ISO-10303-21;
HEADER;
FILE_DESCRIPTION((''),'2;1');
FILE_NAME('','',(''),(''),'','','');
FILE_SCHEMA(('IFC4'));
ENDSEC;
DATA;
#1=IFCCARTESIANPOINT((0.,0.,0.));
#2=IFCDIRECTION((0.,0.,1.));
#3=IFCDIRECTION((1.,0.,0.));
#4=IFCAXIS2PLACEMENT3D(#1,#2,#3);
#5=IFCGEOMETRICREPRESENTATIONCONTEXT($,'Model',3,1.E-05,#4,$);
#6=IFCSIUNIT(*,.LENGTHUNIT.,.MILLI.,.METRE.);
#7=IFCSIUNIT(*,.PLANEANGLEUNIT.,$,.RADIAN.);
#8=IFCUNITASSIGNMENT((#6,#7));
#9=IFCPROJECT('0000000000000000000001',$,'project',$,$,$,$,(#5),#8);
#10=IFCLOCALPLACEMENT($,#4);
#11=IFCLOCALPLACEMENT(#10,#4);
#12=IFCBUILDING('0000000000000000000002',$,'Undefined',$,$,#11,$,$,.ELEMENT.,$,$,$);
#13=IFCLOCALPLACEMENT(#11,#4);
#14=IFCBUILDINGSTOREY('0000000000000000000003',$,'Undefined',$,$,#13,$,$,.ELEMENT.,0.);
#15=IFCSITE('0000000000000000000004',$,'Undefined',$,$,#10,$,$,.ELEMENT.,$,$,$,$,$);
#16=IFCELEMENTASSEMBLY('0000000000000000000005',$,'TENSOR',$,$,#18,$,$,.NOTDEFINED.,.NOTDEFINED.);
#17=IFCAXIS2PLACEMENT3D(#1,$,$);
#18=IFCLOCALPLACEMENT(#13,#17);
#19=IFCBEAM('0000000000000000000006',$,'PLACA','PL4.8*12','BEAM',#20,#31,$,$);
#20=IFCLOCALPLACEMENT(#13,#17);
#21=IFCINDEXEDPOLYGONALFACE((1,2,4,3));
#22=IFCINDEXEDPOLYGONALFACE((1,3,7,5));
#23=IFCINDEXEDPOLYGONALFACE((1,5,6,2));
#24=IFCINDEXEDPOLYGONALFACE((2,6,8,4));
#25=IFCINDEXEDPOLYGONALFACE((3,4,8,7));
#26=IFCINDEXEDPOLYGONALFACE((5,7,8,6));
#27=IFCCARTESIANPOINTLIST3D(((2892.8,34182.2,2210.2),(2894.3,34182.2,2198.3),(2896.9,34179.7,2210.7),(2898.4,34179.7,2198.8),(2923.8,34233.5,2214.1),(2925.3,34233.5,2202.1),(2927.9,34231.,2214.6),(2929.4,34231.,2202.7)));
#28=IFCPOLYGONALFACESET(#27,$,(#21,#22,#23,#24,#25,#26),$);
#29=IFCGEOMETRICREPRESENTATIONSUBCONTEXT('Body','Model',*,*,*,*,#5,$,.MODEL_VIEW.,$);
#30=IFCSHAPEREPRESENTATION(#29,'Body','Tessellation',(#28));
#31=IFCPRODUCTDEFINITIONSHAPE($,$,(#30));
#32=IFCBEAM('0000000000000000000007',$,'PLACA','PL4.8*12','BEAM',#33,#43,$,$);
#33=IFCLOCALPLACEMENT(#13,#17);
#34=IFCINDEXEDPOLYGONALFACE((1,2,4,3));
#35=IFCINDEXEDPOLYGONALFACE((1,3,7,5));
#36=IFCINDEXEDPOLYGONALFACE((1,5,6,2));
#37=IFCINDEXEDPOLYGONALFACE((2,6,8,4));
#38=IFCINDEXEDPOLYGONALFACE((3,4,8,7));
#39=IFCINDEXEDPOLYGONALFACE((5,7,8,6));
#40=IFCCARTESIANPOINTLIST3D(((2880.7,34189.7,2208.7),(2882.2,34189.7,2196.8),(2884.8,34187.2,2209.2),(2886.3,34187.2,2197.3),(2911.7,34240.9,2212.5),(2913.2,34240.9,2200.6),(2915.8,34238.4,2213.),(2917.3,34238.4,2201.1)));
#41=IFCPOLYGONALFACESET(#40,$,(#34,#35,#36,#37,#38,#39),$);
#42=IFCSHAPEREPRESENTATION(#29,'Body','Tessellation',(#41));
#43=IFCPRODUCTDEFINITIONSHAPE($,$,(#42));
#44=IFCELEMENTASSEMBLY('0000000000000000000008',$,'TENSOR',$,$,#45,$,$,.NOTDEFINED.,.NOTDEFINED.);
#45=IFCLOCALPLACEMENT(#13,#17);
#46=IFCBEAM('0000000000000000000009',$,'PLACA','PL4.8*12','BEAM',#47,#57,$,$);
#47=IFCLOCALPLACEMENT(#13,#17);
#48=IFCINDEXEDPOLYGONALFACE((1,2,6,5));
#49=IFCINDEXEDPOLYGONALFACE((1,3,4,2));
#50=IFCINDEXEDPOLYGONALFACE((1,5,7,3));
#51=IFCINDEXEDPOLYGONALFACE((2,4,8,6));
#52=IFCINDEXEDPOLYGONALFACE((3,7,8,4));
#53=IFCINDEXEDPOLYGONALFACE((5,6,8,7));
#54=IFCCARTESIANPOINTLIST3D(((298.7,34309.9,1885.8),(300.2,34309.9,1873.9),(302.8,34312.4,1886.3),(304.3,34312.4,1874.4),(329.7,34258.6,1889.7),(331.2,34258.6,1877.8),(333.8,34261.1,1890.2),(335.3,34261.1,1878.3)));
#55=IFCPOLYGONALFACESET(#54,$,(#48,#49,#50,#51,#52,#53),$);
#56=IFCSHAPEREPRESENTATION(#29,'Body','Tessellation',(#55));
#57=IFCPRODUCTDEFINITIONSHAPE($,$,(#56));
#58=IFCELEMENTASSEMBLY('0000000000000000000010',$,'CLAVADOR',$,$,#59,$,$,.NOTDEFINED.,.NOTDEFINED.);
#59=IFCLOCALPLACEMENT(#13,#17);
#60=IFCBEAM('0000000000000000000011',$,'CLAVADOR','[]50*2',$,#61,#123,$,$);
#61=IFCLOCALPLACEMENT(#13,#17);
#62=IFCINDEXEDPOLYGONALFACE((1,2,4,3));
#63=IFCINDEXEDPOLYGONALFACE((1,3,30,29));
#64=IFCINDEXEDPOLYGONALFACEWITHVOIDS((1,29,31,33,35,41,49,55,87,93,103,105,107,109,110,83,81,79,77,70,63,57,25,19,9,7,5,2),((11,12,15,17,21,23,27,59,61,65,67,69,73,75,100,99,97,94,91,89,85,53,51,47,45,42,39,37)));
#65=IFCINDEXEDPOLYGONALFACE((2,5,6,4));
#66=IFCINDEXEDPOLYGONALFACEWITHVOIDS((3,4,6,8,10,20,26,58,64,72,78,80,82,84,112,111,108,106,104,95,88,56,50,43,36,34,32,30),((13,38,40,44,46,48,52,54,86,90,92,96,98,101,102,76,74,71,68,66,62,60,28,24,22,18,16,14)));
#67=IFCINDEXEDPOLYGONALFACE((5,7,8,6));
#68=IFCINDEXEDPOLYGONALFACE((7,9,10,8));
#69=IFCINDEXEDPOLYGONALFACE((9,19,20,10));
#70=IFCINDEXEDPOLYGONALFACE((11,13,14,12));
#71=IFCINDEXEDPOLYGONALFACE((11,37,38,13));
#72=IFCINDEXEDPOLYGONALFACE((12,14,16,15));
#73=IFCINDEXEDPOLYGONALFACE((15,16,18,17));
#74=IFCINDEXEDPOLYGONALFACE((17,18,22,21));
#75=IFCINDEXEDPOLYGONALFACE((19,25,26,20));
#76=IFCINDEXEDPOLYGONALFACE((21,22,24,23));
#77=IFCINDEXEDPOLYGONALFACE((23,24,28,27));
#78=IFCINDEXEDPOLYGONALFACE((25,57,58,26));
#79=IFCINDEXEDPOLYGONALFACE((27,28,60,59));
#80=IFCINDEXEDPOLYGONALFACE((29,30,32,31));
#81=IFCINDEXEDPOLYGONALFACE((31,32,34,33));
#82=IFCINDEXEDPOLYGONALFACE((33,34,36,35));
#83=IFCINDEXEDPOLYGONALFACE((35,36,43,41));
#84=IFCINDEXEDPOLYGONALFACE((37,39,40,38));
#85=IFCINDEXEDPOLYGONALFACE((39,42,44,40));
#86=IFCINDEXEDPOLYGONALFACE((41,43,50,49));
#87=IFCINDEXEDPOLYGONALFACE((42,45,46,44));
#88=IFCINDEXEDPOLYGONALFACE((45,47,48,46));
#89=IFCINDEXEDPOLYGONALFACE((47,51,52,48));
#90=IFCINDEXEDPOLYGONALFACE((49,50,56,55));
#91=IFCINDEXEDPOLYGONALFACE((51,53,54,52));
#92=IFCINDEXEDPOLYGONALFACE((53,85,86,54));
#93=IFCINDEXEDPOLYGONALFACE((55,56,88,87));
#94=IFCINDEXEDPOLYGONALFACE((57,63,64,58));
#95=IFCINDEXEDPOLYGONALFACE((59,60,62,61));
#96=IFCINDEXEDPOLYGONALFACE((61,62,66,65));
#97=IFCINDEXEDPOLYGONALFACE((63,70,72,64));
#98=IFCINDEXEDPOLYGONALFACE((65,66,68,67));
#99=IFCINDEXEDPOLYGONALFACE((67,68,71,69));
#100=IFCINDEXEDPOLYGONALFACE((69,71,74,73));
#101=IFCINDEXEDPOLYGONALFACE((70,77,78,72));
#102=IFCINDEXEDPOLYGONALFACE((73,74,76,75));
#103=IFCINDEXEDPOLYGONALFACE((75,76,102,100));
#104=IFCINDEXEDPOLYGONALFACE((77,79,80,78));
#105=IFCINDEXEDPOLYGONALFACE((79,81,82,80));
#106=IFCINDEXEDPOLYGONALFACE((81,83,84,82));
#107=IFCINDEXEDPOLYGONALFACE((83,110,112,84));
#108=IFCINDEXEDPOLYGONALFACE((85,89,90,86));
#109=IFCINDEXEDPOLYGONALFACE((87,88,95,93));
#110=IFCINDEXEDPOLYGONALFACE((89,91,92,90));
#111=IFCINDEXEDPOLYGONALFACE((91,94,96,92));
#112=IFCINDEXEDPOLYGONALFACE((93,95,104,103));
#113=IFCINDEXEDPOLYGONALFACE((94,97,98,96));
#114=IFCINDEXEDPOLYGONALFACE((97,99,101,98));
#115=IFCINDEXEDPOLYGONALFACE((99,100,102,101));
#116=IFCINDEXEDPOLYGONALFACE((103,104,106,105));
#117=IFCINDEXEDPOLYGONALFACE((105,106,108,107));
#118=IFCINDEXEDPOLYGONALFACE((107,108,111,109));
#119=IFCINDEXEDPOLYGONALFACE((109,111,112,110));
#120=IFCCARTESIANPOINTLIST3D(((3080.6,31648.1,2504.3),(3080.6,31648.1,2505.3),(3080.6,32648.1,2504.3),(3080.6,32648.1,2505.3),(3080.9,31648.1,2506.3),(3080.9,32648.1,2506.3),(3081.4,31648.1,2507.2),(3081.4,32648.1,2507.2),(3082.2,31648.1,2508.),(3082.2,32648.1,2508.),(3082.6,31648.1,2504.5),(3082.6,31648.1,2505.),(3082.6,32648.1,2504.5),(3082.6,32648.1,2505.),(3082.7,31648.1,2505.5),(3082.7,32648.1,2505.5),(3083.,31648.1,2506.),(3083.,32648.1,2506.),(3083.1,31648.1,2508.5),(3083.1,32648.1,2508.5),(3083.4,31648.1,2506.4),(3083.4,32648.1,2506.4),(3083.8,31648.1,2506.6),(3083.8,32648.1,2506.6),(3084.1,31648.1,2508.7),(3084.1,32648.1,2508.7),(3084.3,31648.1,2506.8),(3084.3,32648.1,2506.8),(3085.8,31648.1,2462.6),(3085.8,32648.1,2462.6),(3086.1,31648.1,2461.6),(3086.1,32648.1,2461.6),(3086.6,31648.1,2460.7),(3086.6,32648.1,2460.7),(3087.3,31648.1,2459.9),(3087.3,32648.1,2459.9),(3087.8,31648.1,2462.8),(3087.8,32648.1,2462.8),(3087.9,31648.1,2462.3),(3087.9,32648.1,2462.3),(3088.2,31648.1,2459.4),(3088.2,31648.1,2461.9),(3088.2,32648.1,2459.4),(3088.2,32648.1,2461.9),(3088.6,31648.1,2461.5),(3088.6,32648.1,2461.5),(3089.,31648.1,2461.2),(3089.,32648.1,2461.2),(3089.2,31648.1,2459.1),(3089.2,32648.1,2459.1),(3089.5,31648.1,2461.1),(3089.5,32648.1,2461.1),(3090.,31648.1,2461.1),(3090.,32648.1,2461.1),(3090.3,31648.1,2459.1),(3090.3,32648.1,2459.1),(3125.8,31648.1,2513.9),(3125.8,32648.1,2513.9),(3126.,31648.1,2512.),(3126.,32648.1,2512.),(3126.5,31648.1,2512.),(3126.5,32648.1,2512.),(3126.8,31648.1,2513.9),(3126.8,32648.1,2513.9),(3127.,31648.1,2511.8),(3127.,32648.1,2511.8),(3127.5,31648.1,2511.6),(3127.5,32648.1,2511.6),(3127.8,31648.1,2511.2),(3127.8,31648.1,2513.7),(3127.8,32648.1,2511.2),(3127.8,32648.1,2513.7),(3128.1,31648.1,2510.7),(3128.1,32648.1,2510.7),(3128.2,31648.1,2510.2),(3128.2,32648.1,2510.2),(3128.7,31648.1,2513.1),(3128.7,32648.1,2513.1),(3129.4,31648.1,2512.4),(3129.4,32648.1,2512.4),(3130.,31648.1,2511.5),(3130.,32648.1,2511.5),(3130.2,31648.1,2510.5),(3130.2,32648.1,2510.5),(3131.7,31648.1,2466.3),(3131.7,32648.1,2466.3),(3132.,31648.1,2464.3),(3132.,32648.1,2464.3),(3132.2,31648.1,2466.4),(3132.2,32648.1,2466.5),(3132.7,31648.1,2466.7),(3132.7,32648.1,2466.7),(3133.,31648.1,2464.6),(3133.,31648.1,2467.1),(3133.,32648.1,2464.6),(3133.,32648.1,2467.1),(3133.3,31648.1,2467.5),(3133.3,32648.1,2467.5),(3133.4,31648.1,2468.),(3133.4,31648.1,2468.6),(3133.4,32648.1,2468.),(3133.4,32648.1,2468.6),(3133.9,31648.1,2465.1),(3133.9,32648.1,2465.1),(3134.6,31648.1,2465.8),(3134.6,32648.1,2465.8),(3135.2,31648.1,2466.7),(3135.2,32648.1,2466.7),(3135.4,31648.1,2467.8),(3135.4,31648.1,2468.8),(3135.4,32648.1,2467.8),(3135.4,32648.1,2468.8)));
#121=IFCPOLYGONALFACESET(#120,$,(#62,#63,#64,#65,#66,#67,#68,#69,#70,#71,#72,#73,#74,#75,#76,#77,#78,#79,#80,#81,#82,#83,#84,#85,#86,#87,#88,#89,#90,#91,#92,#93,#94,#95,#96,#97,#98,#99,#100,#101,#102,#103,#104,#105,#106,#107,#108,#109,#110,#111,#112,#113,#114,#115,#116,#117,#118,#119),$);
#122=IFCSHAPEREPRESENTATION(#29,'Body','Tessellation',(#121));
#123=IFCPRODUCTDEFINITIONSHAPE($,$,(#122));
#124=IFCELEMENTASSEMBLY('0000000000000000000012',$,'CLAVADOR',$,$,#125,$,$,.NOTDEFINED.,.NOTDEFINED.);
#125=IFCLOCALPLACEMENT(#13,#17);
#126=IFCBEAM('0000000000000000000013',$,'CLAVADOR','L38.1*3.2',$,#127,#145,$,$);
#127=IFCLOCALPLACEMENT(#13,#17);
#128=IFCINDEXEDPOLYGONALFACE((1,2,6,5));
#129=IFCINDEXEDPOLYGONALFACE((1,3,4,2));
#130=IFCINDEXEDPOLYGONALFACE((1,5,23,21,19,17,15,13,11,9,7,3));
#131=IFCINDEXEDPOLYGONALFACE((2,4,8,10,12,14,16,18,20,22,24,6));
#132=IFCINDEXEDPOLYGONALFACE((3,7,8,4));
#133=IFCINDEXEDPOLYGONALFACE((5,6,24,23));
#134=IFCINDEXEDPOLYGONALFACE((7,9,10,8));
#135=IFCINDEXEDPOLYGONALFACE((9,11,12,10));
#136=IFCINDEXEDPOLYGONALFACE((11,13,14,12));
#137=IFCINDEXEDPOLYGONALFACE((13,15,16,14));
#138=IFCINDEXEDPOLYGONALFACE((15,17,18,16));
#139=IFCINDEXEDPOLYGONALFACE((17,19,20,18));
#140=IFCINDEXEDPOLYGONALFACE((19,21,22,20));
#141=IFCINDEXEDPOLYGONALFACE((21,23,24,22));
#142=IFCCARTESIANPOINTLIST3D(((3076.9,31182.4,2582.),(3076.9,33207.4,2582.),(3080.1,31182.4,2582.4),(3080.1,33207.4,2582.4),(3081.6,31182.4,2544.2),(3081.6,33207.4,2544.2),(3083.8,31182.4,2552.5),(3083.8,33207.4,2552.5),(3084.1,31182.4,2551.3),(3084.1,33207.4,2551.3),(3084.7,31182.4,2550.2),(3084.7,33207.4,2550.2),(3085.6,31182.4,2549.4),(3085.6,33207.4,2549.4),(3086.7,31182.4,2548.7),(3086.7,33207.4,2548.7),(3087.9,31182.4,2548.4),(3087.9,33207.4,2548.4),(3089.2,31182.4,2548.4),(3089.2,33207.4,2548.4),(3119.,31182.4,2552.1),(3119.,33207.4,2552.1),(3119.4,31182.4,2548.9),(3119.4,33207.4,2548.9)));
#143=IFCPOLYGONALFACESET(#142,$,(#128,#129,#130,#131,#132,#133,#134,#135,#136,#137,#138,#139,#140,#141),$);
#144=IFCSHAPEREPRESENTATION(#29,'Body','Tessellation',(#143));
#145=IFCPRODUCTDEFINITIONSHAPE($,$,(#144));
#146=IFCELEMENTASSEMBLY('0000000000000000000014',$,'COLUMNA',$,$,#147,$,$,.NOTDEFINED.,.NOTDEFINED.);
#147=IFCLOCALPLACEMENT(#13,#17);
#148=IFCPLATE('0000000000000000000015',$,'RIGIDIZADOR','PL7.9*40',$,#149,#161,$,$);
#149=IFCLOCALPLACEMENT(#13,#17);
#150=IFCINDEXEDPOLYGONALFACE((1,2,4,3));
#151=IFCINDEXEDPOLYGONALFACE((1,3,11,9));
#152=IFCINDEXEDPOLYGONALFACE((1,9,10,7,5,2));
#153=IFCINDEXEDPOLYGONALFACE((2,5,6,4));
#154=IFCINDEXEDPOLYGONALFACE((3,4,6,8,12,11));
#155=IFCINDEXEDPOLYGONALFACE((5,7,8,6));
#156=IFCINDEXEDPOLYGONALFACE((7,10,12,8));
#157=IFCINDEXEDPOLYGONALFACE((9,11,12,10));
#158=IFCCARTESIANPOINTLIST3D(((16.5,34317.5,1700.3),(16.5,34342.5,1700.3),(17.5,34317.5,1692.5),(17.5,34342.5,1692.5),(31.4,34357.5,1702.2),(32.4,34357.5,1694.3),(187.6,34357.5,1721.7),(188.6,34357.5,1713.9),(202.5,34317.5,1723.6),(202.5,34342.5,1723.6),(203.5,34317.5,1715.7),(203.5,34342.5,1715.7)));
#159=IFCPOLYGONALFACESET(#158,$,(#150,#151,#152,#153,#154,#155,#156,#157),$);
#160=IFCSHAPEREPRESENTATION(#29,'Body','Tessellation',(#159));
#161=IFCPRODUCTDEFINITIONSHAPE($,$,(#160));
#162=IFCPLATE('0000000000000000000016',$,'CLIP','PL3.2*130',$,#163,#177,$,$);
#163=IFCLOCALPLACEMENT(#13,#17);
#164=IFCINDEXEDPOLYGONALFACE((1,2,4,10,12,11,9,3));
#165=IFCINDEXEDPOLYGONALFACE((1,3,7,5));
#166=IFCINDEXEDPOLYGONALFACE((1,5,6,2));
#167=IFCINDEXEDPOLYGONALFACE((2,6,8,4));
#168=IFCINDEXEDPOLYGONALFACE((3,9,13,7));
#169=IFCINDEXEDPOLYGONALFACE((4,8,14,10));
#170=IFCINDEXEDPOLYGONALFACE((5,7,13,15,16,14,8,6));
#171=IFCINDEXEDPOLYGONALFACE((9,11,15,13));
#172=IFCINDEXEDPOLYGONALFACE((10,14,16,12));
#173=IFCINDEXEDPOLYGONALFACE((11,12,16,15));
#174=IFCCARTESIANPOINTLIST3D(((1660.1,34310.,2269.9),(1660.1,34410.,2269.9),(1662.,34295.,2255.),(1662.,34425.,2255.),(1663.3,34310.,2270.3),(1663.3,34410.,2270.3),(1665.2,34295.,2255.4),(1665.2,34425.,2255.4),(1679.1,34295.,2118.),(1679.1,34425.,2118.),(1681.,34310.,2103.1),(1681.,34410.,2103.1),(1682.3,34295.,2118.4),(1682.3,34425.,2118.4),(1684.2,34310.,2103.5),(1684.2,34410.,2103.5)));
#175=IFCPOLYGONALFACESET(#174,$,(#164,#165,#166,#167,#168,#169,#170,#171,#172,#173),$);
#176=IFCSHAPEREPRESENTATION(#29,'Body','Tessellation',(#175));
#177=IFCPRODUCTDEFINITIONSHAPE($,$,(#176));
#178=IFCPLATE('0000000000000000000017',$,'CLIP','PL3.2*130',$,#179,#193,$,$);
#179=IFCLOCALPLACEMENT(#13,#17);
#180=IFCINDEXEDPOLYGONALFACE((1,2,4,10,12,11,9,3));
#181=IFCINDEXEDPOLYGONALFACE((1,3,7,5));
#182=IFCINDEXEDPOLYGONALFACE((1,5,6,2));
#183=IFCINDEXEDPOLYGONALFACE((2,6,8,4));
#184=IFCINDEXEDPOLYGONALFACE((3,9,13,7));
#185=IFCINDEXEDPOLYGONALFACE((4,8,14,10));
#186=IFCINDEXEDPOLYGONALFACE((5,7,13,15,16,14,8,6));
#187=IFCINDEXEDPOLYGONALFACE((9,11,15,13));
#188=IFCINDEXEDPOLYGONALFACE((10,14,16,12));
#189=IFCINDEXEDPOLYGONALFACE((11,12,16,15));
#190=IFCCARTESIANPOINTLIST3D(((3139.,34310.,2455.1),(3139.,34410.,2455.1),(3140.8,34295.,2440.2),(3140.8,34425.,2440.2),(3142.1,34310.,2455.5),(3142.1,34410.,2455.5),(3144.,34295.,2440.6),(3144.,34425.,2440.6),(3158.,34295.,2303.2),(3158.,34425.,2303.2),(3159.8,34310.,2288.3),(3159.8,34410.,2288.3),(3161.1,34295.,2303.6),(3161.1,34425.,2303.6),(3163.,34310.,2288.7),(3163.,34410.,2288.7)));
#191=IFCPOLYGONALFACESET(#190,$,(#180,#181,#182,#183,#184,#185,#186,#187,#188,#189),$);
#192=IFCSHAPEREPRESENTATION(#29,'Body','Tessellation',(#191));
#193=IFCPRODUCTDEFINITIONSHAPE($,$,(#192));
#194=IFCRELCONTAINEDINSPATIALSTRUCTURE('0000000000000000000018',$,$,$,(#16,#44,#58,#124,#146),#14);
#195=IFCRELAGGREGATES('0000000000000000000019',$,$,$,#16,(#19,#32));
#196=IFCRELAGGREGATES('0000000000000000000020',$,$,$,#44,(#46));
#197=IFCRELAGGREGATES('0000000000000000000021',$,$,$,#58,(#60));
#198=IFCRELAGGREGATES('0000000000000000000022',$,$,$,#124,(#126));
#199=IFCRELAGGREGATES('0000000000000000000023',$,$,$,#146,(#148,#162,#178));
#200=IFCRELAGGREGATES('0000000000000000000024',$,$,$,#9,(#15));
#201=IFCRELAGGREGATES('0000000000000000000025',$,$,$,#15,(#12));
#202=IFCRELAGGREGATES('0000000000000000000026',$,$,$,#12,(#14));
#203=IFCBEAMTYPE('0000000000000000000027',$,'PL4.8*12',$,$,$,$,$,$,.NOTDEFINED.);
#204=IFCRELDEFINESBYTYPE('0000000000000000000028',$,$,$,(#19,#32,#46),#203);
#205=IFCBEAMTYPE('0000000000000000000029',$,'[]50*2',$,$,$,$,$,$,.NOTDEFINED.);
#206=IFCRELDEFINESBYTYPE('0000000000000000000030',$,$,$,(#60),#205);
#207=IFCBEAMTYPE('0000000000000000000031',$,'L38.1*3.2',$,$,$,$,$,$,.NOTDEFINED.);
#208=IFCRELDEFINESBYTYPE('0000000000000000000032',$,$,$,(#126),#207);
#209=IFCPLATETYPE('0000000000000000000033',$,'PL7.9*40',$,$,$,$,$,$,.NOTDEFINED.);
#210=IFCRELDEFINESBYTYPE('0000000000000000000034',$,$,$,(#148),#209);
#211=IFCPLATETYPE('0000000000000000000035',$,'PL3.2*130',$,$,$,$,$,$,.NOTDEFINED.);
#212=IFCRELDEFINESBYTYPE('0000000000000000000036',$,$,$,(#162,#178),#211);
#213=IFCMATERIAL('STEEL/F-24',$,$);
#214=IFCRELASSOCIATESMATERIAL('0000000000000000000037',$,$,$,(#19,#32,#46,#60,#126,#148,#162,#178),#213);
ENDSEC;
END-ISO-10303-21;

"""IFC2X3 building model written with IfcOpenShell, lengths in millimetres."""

from ifc_helpers import new_model, si_unit, frame, origin_with_axes, origin_2d_with_axis, place, context, subcontext, project, spatial, polyline, rectangle, hollow_rectangle, l_section, outline, extrude, material, type_object, element, aggregate, save


model = new_model("IFC2X3")

# Units and contexts
model_context = context("Model", 3, precision=1e-05, world=origin_with_axes())
body_context = subcontext(model_context, "Body", "Model", "MODEL_VIEW")
ifc_project = project(units=[si_unit("LENGTHUNIT", "METRE", prefix="MILLI"), si_unit("PLANEANGLEUNIT", "RADIAN")], contexts=[model_context])

# Site, building, storey
site_placement = place(None, origin_with_axes())
site = spatial("IfcSite", under=ifc_project, at=site_placement, Name="Undefined", CompositionType="ELEMENT")
building_placement = place(site_placement, origin_with_axes())
building = spatial("IfcBuilding", under=site, at=building_placement, Name="Undefined", CompositionType="ELEMENT")
storey_placement = place(building_placement, origin_with_axes())
storey = spatial("IfcBuildingStorey", under=building, at=storey_placement, Name="Undefined", CompositionType="ELEMENT", Elevation=0.0)

# Element assemblies, beams
assembly_1_placement = place(storey_placement, origin_with_axes())
assembly_1 = element("IfcElementAssembly", 1, at=assembly_1_placement, inside=storey, Name="TENSOR", AssemblyPlace="NOTDEFINED", PredefinedType="NOTDEFINED")
ifc_material_1 = material(Name="STEEL/F-24")
beam_type_1 = type_object("IfcBeamType", Name="PL4.8*12", PredefinedType="NOTDEFINED")
beam_1_placement = place(assembly_1_placement, frame((2895.6, 34181.0, 2204.5), z_axis=(0.124075, 0.0, -0.992273), x_axis=(0.5164, 0.85391, 0.064571)))
beam_1 = element("IfcBeam", 2, at=beam_1_placement, type_object=beam_type_1, material=ifc_material_1, Name="PLACA", Description="PL4.8*12", ObjectType="BEAM", context=body_context, shape_type="SweptSolid", body=[
    extrude(rectangle(XDim=4.8, YDim=12.0, at=origin_2d_with_axis()), frame((60.0, 0.0, 0.0), z_axis=(-1.0, 0.0, 0.0), x_axis=(0.0, -1.0, 0.0)), (0.0, 0.0, 1.0), 60.0),
])
beam_2_placement = place(assembly_1_placement, frame((2883.5, 34188.4, 2203.0), z_axis=(0.124075, 0.0, -0.992273), x_axis=(0.5164, 0.85391, 0.064571)))
beam_2 = element("IfcBeam", 3, at=beam_2_placement, type_object=beam_type_1, material=ifc_material_1, Name="PLACA", Description="PL4.8*12", ObjectType="BEAM", context=body_context, shape_type="SweptSolid", body=[
    extrude(rectangle(XDim=4.8, YDim=12.0, at=origin_2d_with_axis()), frame((60.0, 0.0, 0.0), z_axis=(-1.0, 0.0, 0.0), x_axis=(0.0, -1.0, 0.0)), (0.0, 0.0, 1.0), 60.0),
])
aggregate(assembly_1, [beam_1, beam_2])
assembly_2_placement = place(storey_placement, origin_with_axes())
assembly_2 = element("IfcElementAssembly", 4, at=assembly_2_placement, inside=storey, Name="TENSOR", AssemblyPlace="NOTDEFINED", PredefinedType="NOTDEFINED")
beam_3_placement = place(assembly_2_placement, frame((301.5, 34311.1, 1880.1), z_axis=(0.124075, 0.0, -0.992273), x_axis=(0.5164, -0.85391, 0.064571)))
beam_3 = element("IfcBeam", 5, at=beam_3_placement, type_object=beam_type_1, material=ifc_material_1, Name="PLACA", Description="PL4.8*12", ObjectType="BEAM", context=body_context, shape_type="SweptSolid", body=[
    extrude(rectangle(XDim=4.8, YDim=12.0, at=origin_2d_with_axis()), frame((60.0, 0.0, 0.0), z_axis=(-1.0, 0.0, 0.0), x_axis=(0.0, -1.0, 0.0)), (0.0, 0.0, 1.0), 60.0),
])
aggregate(assembly_2, [beam_3])

# Element assemblies, beams
assembly_3_placement = place(storey_placement, origin_with_axes())
assembly_3 = element("IfcElementAssembly", 6, at=assembly_3_placement, inside=storey, Name="CLAVADOR", AssemblyPlace="NOTDEFINED", PredefinedType="NOTDEFINED")
beam_type_2 = type_object("IfcBeamType", Name="[]50*2", PredefinedType="NOTDEFINED")
beam_4_placement = place(assembly_3_placement, frame((3108.0, 31648.1, 2486.5), z_axis=(-0.992273, 0.0, -0.124075), x_axis=(0.0, 1.0, 0.000001)))
beam_4 = element("IfcBeam", 7, at=beam_4_placement, type_object=beam_type_2, material=ifc_material_1, Name="CLAVADOR", Description="[]50*2", context=body_context, shape_type="SweptSolid", body=[
    extrude(hollow_rectangle(XDim=50.0, YDim=50.0, WallThickness=2.0, InnerFilletRadius=2.0, OuterFilletRadius=4.0, at=origin_2d_with_axis()), frame((1000.0, 0.0, 0.0), z_axis=(-1.0, 0.0, 0.0), x_axis=(0.0, -1.0, 0.0)), (0.0, 0.0, 1.0), 1000.0),
])
aggregate(assembly_3, [beam_4])
assembly_4_placement = place(storey_placement, origin_with_axes())
assembly_4 = element("IfcElementAssembly", 8, at=assembly_4_placement, inside=storey, Name="CLAVADOR", AssemblyPlace="NOTDEFINED", PredefinedType="NOTDEFINED")
beam_type_3 = type_object("IfcBeamType", Name="L38.1*3.2", PredefinedType="NOTDEFINED")
beam_5_placement = place(assembly_4_placement, frame((3098.2, 33207.4, 2565.5), z_axis=(0.992273, 0.0, 0.124075), x_axis=(0.0, -1.0, 0.0)))
beam_5 = element("IfcBeam", 9, at=beam_5_placement, type_object=beam_type_3, material=ifc_material_1, Name="CLAVADOR", Description="L38.1*3.2", context=body_context, shape_type="SweptSolid", body=[
    extrude(l_section(Depth=38.1, Width=38.1, Thickness=3.2, FilletRadius=4.8, at=origin_2d_with_axis()), frame((2025.0, 0.0, 0.0), z_axis=(-1.0, 0.0, 0.0), x_axis=(0.0, -1.0, 0.0)), (0.0, 0.0, 1.0), 2025.0),
])
aggregate(assembly_4, [beam_5])

# Element assembly, plates
assembly_5_placement = place(storey_placement, origin_with_axes())
assembly_5 = element("IfcElementAssembly", 10, at=assembly_5_placement, inside=storey, Name="COLUMNA", AssemblyPlace="NOTDEFINED", PredefinedType="NOTDEFINED")
plate_type_1 = type_object("IfcPlateType", Name="PL7.9*40", PredefinedType="NOTDEFINED")
plate_1_placement = place(assembly_5_placement, frame((203.0, 34317.5, 1719.6), z_axis=(-0.124075, 0.0, 0.992273), x_axis=(0.0, 1.0, 0.0)))
plate_1 = element("IfcPlate", 11, at=plate_1_placement, type_object=plate_type_1, material=ifc_material_1, Name="RIGIDIZADOR", Description="PL7.9*40", context=body_context, shape_type="SweptSolid", body=[
    extrude(outline(polyline([(0.0, 0.0), (25.0, 0.0), (40.0, 15.0), (40.0, 172.5), (25.0, 187.5), (0.0, 187.5), (0.0, 0.0)])), frame((0.0, 0.0, -4.0), z_axis=(0.0, 0.0, 1.0), x_axis=(1.0, 0.0, 0.0)), (0.0, 0.0, 1.0), 7.9),
])
plate_type_2 = type_object("IfcPlateType", Name="PL3.2*130", PredefinedType="NOTDEFINED")
plate_2_placement = place(assembly_5_placement, frame((1661.7, 34295.0, 2270.1), z_axis=(-0.992275, 0.0, -0.124059), x_axis=(0.0, 1.0, 0.0)))
plate_2 = element("IfcPlate", 12, at=plate_2_placement, type_object=plate_type_2, material=ifc_material_1, Name="CLIP", Description="PL3.2*130", context=body_context, shape_type="SweptSolid", body=[
    extrude(outline(polyline([(0.0, 15.0), (15.0, 0.0), (115.0, 0.0), (130.0, 15.0), (130.0, 153.1), (115.0, 168.1), (15.0, 168.1), (0.0, 153.1), (0.0, 15.0)])), frame((0.0, 0.0, -1.6), z_axis=(0.0, 0.0, 1.0), x_axis=(1.0, 0.0, 0.0)), (0.0, 0.0, 1.0), 3.2),
])
plate_3_placement = place(assembly_5_placement, frame((3140.5, 34295.0, 2455.3), z_axis=(-0.992275, 0.0, -0.124059), x_axis=(0.0, 1.0, 0.0)))
plate_3 = element("IfcPlate", 13, at=plate_3_placement, type_object=plate_type_2, material=ifc_material_1, Name="CLIP", Description="PL3.2*130", context=body_context, shape_type="SweptSolid", body=[
    extrude(outline(polyline([(0.0, 15.0), (15.0, 0.0), (115.0, 0.0), (130.0, 15.0), (130.0, 153.1), (115.0, 168.1), (15.0, 168.1), (0.0, 153.1), (0.0, 15.0)])), frame((0.0, 0.0, -1.6), z_axis=(0.0, 0.0, 1.0), x_axis=(1.0, 0.0, 0.0)), (0.0, 0.0, 1.0), 3.2),
])
aggregate(assembly_5, [plate_1, plate_2, plate_3])

save(model, "model.ifc")
